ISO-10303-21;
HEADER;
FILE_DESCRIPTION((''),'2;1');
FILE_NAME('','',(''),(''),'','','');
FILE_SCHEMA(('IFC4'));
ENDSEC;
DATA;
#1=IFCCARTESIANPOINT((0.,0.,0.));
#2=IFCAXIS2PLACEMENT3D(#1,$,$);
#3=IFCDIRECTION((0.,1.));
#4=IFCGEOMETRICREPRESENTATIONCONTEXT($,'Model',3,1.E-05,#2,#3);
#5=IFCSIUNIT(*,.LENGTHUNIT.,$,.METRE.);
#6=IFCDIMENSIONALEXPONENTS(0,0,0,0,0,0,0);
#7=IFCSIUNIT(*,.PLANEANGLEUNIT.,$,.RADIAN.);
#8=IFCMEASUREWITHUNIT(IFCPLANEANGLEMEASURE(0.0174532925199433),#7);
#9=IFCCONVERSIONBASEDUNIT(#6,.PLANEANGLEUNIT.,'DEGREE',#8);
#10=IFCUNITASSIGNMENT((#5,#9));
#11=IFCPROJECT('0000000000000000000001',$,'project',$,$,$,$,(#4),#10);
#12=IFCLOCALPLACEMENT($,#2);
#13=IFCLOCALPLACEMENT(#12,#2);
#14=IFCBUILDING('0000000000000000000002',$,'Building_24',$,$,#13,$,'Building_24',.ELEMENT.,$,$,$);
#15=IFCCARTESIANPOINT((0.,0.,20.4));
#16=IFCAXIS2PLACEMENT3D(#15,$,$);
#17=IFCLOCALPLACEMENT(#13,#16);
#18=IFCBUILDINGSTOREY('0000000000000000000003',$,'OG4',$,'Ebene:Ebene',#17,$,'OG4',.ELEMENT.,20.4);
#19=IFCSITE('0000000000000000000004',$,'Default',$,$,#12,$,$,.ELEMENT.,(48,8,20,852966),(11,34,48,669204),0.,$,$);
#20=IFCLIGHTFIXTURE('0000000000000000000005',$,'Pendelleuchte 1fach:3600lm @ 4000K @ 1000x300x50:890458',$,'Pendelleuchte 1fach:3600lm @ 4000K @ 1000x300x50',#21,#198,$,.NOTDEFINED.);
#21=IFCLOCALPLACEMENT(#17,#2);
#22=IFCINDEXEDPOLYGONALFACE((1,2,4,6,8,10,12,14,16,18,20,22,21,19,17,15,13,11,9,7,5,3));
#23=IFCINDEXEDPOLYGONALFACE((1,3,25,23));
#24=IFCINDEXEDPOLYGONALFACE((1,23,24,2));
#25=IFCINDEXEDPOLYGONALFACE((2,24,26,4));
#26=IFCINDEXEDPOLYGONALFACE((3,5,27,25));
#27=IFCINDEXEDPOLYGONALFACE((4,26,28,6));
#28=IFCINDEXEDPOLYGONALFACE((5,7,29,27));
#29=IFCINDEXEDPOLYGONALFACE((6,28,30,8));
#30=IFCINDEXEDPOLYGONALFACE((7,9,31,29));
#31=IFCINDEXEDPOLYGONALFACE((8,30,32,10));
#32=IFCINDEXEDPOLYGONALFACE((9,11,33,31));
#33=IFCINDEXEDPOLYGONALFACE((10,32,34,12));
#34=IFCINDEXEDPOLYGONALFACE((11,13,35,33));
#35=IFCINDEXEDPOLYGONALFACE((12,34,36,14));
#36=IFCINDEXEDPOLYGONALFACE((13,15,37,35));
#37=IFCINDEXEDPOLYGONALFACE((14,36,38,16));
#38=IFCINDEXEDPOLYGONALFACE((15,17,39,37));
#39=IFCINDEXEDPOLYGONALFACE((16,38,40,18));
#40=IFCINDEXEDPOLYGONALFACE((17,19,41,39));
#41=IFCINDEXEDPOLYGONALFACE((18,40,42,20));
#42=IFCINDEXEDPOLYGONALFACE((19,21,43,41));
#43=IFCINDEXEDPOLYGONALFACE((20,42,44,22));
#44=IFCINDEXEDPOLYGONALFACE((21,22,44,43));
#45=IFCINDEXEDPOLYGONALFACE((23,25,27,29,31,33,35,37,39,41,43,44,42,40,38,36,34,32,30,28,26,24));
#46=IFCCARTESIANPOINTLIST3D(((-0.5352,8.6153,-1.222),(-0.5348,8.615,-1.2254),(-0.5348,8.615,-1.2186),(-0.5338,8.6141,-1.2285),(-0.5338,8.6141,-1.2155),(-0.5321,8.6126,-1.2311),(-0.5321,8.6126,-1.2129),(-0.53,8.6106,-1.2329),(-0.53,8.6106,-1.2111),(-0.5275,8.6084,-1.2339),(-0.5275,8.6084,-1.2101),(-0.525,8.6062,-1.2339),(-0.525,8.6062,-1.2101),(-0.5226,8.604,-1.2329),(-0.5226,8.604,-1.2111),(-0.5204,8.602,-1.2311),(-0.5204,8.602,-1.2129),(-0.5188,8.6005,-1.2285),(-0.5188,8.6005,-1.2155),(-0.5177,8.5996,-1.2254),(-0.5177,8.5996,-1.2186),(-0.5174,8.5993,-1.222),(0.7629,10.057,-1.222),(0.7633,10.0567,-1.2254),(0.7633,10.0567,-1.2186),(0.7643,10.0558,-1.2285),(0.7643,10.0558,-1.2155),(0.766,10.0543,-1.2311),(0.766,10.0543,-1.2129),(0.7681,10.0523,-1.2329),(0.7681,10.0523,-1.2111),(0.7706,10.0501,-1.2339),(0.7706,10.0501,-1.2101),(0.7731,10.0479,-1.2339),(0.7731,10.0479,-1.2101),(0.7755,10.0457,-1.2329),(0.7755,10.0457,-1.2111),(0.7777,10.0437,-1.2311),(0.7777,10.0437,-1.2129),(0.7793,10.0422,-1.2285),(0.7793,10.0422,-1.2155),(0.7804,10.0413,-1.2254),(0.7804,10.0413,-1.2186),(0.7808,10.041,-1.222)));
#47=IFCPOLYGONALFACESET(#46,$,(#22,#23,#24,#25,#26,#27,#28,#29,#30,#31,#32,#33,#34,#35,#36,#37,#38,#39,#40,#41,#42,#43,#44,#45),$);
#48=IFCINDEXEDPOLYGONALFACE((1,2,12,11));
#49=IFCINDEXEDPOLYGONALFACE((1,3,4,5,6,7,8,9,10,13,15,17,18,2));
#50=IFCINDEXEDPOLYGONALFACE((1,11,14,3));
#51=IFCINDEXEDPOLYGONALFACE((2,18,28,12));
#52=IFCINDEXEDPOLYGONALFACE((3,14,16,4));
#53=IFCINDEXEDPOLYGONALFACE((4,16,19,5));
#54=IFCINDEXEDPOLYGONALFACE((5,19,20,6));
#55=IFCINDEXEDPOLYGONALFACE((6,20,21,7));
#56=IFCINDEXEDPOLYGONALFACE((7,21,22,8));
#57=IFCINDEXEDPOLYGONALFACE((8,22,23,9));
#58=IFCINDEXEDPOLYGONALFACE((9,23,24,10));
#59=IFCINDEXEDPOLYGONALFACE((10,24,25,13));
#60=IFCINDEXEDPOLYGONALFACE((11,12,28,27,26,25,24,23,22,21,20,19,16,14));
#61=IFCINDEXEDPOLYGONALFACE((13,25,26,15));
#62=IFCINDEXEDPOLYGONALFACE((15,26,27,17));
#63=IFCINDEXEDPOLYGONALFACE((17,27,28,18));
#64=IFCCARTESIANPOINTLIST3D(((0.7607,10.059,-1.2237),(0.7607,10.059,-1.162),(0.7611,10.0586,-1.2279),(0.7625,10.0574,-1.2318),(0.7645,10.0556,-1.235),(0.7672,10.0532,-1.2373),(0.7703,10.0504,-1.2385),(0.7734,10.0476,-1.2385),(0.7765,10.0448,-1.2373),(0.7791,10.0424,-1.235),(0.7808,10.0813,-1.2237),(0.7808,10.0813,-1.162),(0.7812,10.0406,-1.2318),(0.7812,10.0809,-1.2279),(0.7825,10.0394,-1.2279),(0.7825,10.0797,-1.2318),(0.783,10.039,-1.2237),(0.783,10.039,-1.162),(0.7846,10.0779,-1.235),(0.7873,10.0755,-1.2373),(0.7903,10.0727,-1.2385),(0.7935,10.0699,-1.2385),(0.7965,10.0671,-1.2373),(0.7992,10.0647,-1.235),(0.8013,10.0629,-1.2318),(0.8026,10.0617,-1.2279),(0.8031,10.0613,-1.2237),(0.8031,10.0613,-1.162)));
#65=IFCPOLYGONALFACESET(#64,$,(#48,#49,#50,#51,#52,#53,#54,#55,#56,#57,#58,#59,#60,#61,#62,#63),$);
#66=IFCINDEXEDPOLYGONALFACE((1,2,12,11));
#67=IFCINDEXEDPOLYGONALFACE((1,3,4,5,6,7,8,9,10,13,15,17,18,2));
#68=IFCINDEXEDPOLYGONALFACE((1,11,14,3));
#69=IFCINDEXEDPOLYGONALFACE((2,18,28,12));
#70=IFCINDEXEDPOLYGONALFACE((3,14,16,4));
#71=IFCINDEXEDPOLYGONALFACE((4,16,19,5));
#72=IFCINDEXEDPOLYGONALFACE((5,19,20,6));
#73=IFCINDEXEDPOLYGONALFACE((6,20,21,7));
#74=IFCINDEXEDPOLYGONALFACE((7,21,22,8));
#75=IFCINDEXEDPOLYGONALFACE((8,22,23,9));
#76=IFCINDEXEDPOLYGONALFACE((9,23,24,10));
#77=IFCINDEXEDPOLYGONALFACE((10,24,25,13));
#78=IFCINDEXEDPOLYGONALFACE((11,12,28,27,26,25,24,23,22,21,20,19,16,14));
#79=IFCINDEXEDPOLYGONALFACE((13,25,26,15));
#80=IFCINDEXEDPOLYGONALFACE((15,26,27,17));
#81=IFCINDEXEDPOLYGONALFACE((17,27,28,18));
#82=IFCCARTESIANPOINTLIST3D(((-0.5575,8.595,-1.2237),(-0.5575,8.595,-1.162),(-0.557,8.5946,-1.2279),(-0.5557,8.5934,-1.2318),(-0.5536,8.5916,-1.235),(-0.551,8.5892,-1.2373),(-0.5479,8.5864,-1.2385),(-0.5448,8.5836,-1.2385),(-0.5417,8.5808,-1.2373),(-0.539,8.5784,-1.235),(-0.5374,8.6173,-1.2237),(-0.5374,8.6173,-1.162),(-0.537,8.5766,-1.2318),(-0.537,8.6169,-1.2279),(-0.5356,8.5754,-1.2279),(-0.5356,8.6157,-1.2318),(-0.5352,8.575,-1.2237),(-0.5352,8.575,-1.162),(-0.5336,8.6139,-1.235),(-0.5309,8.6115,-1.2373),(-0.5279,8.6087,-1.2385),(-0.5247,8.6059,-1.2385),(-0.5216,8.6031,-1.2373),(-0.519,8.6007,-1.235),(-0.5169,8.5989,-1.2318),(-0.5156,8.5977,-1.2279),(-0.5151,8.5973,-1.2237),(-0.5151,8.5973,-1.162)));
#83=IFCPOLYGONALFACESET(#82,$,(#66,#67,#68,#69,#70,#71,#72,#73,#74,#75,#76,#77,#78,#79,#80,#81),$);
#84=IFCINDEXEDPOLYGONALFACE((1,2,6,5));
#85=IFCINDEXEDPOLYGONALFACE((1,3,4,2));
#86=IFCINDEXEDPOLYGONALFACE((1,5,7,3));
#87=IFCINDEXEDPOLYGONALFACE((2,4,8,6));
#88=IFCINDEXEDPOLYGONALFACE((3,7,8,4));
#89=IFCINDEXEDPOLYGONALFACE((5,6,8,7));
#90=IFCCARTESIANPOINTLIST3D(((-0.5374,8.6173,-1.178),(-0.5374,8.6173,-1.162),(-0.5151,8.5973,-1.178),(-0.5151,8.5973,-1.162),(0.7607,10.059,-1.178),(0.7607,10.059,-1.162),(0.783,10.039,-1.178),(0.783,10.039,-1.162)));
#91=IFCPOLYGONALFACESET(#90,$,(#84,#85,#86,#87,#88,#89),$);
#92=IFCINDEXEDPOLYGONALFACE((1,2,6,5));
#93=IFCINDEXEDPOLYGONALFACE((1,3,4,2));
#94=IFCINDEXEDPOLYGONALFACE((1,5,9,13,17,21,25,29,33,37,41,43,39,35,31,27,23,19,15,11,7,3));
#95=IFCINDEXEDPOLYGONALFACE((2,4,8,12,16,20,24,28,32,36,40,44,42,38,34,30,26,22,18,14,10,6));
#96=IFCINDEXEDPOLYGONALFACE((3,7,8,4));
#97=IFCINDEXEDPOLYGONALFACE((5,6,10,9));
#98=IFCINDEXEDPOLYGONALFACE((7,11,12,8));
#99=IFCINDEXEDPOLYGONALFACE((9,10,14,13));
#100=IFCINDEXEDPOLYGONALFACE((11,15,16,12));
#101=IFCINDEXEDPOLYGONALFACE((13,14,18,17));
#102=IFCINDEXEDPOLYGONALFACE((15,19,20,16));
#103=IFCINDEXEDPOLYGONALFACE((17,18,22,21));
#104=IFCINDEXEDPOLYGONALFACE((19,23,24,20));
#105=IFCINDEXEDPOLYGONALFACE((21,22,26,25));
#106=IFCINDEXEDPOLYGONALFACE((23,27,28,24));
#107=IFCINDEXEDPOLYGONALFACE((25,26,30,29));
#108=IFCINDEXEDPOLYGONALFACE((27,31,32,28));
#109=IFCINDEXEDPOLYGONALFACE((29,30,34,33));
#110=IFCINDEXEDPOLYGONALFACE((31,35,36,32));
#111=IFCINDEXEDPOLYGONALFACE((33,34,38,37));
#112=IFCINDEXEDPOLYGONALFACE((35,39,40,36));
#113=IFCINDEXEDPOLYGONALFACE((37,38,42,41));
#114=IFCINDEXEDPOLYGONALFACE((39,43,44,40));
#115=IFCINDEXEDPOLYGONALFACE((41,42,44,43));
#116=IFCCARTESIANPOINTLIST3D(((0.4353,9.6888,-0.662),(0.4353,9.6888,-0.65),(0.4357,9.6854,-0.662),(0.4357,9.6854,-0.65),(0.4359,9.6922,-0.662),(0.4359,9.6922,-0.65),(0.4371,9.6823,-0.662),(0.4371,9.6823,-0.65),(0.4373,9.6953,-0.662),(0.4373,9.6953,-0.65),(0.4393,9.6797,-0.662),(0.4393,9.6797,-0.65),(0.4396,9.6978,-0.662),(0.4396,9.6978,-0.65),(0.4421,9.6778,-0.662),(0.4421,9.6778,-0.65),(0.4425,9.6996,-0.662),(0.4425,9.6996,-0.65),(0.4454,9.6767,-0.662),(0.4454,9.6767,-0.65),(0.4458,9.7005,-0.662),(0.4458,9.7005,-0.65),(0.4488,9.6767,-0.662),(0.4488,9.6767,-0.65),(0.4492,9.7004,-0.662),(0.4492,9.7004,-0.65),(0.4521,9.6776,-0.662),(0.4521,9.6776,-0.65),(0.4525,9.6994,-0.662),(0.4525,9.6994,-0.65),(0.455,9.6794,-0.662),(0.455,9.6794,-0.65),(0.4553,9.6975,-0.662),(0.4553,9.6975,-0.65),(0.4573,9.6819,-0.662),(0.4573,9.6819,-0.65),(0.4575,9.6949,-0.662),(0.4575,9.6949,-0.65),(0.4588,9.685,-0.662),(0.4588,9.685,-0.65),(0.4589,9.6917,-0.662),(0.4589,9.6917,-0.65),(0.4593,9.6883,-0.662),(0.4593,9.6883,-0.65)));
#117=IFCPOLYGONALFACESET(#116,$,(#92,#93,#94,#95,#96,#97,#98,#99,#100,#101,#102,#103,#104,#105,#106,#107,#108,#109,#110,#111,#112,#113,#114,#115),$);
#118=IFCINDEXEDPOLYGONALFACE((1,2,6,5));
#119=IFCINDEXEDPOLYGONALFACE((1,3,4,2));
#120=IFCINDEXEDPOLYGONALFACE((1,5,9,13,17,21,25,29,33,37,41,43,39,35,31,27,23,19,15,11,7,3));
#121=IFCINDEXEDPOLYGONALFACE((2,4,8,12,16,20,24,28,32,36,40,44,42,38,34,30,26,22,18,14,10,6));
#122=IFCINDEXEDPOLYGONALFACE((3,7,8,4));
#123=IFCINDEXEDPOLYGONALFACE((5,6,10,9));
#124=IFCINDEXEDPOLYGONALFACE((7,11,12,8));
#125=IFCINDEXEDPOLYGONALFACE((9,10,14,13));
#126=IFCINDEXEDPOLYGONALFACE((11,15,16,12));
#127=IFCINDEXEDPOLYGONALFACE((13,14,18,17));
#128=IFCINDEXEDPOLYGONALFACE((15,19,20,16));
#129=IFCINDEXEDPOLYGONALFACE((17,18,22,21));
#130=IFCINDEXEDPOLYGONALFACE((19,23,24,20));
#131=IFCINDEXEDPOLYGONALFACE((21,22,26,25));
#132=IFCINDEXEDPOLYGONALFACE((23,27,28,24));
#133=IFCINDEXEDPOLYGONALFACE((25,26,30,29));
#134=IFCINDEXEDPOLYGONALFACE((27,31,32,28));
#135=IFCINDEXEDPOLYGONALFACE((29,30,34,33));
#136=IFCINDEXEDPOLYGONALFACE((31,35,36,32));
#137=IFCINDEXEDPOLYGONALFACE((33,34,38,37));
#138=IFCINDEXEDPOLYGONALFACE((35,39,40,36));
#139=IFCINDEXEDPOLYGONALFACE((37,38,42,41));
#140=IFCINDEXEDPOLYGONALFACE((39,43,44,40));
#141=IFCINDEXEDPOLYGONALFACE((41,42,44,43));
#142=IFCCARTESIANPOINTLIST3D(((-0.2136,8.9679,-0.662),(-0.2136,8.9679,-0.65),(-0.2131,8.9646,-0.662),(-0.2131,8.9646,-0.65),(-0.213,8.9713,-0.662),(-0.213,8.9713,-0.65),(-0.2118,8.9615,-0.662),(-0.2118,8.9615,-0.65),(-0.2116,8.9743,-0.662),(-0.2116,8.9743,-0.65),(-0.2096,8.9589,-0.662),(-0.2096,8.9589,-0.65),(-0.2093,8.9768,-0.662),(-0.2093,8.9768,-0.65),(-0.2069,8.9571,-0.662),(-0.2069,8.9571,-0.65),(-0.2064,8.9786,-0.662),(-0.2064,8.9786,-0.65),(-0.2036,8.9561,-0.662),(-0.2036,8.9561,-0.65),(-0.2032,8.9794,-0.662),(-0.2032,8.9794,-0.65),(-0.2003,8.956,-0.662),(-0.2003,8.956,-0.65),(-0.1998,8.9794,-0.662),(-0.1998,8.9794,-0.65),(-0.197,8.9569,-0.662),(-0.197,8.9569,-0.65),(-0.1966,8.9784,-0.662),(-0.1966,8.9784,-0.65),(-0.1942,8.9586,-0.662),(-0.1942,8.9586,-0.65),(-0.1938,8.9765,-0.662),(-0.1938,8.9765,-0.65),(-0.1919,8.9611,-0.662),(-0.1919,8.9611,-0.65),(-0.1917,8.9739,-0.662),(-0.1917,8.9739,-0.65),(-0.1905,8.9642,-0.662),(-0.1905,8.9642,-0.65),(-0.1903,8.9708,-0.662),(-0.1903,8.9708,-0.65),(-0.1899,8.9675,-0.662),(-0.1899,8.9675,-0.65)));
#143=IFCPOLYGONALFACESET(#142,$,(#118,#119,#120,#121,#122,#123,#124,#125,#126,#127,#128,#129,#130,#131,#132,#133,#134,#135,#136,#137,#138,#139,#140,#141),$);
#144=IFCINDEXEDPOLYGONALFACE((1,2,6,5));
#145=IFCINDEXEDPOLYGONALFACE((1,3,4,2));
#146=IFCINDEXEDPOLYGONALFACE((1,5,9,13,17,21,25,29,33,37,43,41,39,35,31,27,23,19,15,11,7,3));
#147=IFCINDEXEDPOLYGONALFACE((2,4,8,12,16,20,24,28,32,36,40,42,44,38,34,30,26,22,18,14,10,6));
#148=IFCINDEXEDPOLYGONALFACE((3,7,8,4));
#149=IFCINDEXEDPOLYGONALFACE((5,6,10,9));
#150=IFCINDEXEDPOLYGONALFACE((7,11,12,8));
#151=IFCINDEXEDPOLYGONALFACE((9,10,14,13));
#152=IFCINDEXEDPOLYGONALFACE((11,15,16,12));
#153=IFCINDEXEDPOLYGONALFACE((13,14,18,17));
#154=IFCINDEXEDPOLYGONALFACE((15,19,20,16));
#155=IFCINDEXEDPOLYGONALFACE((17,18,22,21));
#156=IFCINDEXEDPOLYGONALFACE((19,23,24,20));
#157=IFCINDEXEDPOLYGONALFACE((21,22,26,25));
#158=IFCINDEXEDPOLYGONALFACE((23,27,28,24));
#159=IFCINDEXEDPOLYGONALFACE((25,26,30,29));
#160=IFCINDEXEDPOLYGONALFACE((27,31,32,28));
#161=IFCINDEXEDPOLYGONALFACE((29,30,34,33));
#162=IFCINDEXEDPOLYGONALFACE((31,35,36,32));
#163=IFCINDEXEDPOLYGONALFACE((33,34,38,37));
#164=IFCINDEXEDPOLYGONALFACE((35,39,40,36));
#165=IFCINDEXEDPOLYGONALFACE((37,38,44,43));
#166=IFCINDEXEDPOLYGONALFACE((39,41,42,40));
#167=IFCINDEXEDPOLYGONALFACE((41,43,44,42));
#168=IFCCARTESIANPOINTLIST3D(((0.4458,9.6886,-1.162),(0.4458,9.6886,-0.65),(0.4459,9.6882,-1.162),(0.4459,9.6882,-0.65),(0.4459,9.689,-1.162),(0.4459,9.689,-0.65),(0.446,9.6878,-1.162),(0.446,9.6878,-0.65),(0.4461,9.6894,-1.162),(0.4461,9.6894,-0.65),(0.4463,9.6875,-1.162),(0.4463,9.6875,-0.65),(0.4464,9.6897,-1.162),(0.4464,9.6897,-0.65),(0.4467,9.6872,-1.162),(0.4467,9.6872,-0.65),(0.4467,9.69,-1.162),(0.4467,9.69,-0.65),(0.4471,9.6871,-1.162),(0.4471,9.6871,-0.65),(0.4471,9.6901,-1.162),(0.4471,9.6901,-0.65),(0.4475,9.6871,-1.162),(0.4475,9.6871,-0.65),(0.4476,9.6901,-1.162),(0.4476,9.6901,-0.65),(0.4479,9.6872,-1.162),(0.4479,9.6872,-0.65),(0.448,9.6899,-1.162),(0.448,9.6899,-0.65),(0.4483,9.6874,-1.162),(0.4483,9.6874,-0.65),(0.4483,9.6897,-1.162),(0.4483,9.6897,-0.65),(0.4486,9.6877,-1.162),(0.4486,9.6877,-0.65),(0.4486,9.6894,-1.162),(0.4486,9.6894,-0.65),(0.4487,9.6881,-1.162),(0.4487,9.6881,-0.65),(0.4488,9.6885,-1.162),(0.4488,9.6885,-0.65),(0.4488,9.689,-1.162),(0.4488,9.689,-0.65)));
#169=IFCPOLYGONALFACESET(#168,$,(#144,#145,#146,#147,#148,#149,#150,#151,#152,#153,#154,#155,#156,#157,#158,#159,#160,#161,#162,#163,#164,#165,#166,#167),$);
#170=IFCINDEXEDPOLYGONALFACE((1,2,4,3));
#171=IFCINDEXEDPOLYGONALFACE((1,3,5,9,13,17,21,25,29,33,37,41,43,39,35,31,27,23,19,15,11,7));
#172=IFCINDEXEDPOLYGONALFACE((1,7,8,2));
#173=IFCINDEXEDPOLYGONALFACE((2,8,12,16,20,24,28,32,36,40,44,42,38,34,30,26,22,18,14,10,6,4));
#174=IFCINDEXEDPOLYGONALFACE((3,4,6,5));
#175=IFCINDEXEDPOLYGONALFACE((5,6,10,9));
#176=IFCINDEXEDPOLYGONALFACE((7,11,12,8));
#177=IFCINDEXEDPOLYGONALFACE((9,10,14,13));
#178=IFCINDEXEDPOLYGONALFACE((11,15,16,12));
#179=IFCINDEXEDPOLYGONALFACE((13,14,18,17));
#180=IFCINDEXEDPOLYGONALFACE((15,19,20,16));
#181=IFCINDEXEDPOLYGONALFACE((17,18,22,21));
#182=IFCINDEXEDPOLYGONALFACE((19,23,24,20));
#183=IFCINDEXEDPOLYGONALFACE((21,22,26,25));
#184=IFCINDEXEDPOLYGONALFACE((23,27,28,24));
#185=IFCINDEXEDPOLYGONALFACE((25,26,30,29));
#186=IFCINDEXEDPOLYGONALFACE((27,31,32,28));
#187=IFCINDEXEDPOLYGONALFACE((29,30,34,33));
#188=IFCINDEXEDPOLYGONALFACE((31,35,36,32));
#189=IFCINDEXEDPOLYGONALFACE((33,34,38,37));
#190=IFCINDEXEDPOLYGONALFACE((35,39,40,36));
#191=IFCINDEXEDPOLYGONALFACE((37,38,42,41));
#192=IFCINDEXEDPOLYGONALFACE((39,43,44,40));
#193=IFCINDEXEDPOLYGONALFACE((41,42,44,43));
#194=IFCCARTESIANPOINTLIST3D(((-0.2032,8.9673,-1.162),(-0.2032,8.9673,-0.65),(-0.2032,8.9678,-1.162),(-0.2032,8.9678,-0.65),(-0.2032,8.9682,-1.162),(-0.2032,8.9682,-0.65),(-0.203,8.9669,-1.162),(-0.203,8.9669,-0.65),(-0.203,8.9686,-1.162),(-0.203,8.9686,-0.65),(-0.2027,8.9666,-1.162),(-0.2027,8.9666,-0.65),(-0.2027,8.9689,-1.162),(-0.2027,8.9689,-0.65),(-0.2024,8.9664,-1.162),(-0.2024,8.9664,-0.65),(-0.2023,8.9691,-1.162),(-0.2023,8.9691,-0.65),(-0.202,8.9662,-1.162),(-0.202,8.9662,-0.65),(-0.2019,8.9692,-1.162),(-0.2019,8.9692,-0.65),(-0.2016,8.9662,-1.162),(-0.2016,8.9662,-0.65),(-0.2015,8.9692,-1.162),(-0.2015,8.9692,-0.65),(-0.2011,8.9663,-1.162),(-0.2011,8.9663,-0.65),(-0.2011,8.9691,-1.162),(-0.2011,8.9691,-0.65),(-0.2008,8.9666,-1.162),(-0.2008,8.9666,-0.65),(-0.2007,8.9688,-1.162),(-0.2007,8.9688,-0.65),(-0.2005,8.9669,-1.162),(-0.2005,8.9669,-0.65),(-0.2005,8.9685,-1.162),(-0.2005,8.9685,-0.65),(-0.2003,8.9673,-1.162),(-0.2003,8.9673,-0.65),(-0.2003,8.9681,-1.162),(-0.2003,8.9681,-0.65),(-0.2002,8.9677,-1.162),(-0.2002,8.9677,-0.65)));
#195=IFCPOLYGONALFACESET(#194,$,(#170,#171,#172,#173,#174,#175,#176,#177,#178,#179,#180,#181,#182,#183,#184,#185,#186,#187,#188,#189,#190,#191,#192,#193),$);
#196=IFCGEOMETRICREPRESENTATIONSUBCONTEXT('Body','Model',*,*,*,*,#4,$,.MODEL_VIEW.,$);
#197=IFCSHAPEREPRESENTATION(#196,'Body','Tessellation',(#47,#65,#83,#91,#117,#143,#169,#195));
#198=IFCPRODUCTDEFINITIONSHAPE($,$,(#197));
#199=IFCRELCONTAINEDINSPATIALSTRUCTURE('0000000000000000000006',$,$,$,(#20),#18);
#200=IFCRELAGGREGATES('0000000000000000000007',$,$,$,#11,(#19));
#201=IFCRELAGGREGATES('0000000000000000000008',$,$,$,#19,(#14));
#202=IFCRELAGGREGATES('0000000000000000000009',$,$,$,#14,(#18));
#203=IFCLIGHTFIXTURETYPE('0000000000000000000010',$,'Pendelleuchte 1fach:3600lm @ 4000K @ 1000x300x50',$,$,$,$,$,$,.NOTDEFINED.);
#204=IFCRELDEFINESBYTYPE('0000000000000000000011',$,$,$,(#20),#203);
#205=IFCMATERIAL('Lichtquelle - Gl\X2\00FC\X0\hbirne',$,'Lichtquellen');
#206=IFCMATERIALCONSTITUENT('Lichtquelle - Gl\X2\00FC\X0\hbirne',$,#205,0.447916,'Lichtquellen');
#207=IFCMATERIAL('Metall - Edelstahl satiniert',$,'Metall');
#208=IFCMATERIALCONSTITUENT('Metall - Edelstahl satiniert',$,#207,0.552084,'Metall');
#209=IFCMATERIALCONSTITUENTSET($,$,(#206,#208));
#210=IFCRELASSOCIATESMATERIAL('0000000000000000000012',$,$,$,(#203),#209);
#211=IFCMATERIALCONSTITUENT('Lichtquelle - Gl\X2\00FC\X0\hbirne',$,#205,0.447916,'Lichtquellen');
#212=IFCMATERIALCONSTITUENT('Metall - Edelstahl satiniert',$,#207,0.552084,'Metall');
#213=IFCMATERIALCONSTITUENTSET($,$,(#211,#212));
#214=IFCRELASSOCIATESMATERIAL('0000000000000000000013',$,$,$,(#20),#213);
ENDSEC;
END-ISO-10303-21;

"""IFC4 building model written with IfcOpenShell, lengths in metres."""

from ifc_helpers import new_model, entity, si_unit, converted_unit, direction, frame, origin, place, context, subcontext, project, spatial, line, arc, indexed_curve, outline, extrude, source, transform, mapped, material, constituent, constituent_set, type_object, type_shapes, element, save


model = new_model("IFC4")

# Units and contexts
model_context = context("Model", 3, precision=1e-05, world=origin(), true_north=direction((0.0, 1.0)))
body_context = subcontext(model_context, "Body", "Model", "MODEL_VIEW")
ifc_project = project(units=[si_unit("LENGTHUNIT", "METRE"), converted_unit("PLANEANGLEUNIT", "DEGREE", entity("IfcPlaneAngleMeasure", 0.0174532925199433), si_unit("PLANEANGLEUNIT", "RADIAN"), dimensions=[0, 0, 0, 0, 0, 0, 0])], contexts=[model_context])

# Site, building, storey
site_placement = place(None, origin())
site = spatial("IfcSite", under=ifc_project, at=site_placement, Name="Default", CompositionType="ELEMENT", RefLatitude=(48, 8, 20, 852966), RefLongitude=(11, 34, 48, 669204), RefElevation=0.0)
building_placement = place(site_placement, origin())
building = spatial("IfcBuilding", under=site, at=building_placement, Name="Building_24", LongName="Building_24", CompositionType="ELEMENT")
storey_placement = place(building_placement, frame((0.0, 0.0, 20.4)))
storey = spatial("IfcBuildingStorey", under=building, at=storey_placement, Name="OG4", ObjectType="Ebene:Ebene", LongName="OG4", CompositionType="ELEMENT", Elevation=20.4)

# Light fixture
ifc_material_1 = material(Name="Lichtquelle - Glühbirne", Category="Lichtquellen")
ifc_material_2 = material(Name="Metall - Edelstahl satiniert", Category="Metall")
ifc_constituent_1 = constituent(ifc_material_1, Name="Lichtquelle - Glühbirne", Category="Lichtquellen", fraction=0.447916)
ifc_constituent_2 = constituent(ifc_material_2, Name="Metall - Edelstahl satiniert", Category="Metall", fraction=0.552084)
ifc_constituent_set_1 = constituent_set(constituents=[ifc_constituent_1, ifc_constituent_2])
light_fixture_type = type_object("IfcLightFixtureType", Name="Pendelleuchte 1fach:3600lm @ 4000K @ 1000x300x50", PredefinedType="NOTDEFINED", material=ifc_constituent_set_1)
shared_shape_1 = source(origin(), body_context, "Body", "SweptSolid", [
    extrude(outline(indexed_curve([(-0.012, 0.0), (0.0, -0.012), (0.012, 0.0), (0.0, 0.012)], segments=[arc(1, 2, 3), arc(3, 4, 1)], self_intersect=False)), frame((-0.97, 0.0, -0.572), z_axis=(1.0, 0.0, 0.0), x_axis=(0.0, 1.0, 0.0)), (0.0, 0.0, 1.0), 1.94),
    extrude(outline(indexed_curve([(-0.0308, -0.015), (0.0308, -0.015), (0.0308, 0.015), (-0.0308, 0.015), (-0.0458, 0.0)], segments=[line(1, 2, 3, 4), arc(4, 5, 1)], self_intersect=False)), frame((0.97, 0.0, -0.5428), z_axis=(1.0, 0.0, 0.0), x_axis=(0.0, 0.0, 1.0)), (0.0, 0.0, 1.0), 0.03),
    extrude(outline(indexed_curve([(-0.0308, -0.015), (0.0308, -0.015), (0.0308, 0.015), (-0.0308, 0.015), (-0.0458, 0.0)], segments=[line(1, 2, 3, 4), arc(4, 5, 1)], self_intersect=False)), frame((-1.0, 0.0, -0.5428), z_axis=(1.0, 0.0, 0.0), x_axis=(0.0, 0.0, 1.0)), (0.0, 0.0, 1.0), 0.03),
    extrude(outline(indexed_curve([(-0.97, -0.015), (0.97, -0.015), (0.97, 0.015), (-0.97, 0.015), (-0.97, -0.015)], self_intersect=False)), frame((0.0, 0.0, -0.528), z_axis=(0.0, 0.0, 1.0), x_axis=(-1.0, 0.0, 0.0)), (0.0, 0.0, 1.0), 0.016),
    extrude(outline(indexed_curve([(-0.012, 0.0), (0.0, -0.012), (0.012, 0.0), (0.0, 0.012)], segments=[arc(1, 2, 3), arc(3, 4, 1)], self_intersect=False)), frame((0.485, 0.0, -0.012)), (0.0, 0.0, 1.0), 0.012),
    extrude(outline(indexed_curve([(-0.0118, 0.0), (0.0, -0.0118), (0.0118, 0.0), (0.0, 0.0118)], segments=[arc(1, 2, 3), arc(3, 4, 1)], self_intersect=False)), frame((-0.485, 0.0, -0.012)), (0.0, 0.0, 1.0), 0.012),
    extrude(outline(indexed_curve([(-0.0015, 0.0), (0.0, -0.0015), (0.0015, 0.0), (0.0, 0.0015)], segments=[arc(1, 2, 3), arc(3, 4, 1)], self_intersect=False)), frame((0.485, 0.0, -0.512)), (0.0, 0.0, 1.0), 0.512),
    extrude(outline(indexed_curve([(-0.0015, 0.0), (0.0, -0.0015), (0.0015, 0.0), (0.0, 0.0015)], segments=[arc(1, 2, 3), arc(3, 4, 1)], self_intersect=False)), frame((-0.485, 0.0, -0.512)), (0.0, 0.0, 1.0), 0.512),
])
type_shapes(light_fixture_type, [shared_shape_1])
ifc_constituent_3 = constituent(ifc_material_1, Name="Lichtquelle - Glühbirne", Category="Lichtquellen", fraction=0.447916)
ifc_constituent_4 = constituent(ifc_material_2, Name="Metall - Edelstahl satiniert", Category="Metall", fraction=0.552084)
ifc_constituent_set_2 = constituent_set(constituents=[ifc_constituent_3, ifc_constituent_4])
light_fixture_1_placement = place(storey_placement, frame((0.1228, 9.3281, -0.65), z_axis=(0.0, 0.0, 1.0), x_axis=(0.669131, 0.743145, 0.0)))
element("IfcLightFixture", 1, at=light_fixture_1_placement, inside=storey, type_object=light_fixture_type, material=ifc_constituent_set_2, Name="Pendelleuchte 1fach:3600lm @ 4000K @ 1000x300x50:890458", ObjectType="Pendelleuchte 1fach:3600lm @ 4000K @ 1000x300x50", PredefinedType="NOTDEFINED", context=body_context, shape_type="MappedRepresentation", body=[
    mapped(shared_shape_1, transform((0.0, 0.0, 0.0), scale=1.0)),
])

save(model, "model.ifc")
